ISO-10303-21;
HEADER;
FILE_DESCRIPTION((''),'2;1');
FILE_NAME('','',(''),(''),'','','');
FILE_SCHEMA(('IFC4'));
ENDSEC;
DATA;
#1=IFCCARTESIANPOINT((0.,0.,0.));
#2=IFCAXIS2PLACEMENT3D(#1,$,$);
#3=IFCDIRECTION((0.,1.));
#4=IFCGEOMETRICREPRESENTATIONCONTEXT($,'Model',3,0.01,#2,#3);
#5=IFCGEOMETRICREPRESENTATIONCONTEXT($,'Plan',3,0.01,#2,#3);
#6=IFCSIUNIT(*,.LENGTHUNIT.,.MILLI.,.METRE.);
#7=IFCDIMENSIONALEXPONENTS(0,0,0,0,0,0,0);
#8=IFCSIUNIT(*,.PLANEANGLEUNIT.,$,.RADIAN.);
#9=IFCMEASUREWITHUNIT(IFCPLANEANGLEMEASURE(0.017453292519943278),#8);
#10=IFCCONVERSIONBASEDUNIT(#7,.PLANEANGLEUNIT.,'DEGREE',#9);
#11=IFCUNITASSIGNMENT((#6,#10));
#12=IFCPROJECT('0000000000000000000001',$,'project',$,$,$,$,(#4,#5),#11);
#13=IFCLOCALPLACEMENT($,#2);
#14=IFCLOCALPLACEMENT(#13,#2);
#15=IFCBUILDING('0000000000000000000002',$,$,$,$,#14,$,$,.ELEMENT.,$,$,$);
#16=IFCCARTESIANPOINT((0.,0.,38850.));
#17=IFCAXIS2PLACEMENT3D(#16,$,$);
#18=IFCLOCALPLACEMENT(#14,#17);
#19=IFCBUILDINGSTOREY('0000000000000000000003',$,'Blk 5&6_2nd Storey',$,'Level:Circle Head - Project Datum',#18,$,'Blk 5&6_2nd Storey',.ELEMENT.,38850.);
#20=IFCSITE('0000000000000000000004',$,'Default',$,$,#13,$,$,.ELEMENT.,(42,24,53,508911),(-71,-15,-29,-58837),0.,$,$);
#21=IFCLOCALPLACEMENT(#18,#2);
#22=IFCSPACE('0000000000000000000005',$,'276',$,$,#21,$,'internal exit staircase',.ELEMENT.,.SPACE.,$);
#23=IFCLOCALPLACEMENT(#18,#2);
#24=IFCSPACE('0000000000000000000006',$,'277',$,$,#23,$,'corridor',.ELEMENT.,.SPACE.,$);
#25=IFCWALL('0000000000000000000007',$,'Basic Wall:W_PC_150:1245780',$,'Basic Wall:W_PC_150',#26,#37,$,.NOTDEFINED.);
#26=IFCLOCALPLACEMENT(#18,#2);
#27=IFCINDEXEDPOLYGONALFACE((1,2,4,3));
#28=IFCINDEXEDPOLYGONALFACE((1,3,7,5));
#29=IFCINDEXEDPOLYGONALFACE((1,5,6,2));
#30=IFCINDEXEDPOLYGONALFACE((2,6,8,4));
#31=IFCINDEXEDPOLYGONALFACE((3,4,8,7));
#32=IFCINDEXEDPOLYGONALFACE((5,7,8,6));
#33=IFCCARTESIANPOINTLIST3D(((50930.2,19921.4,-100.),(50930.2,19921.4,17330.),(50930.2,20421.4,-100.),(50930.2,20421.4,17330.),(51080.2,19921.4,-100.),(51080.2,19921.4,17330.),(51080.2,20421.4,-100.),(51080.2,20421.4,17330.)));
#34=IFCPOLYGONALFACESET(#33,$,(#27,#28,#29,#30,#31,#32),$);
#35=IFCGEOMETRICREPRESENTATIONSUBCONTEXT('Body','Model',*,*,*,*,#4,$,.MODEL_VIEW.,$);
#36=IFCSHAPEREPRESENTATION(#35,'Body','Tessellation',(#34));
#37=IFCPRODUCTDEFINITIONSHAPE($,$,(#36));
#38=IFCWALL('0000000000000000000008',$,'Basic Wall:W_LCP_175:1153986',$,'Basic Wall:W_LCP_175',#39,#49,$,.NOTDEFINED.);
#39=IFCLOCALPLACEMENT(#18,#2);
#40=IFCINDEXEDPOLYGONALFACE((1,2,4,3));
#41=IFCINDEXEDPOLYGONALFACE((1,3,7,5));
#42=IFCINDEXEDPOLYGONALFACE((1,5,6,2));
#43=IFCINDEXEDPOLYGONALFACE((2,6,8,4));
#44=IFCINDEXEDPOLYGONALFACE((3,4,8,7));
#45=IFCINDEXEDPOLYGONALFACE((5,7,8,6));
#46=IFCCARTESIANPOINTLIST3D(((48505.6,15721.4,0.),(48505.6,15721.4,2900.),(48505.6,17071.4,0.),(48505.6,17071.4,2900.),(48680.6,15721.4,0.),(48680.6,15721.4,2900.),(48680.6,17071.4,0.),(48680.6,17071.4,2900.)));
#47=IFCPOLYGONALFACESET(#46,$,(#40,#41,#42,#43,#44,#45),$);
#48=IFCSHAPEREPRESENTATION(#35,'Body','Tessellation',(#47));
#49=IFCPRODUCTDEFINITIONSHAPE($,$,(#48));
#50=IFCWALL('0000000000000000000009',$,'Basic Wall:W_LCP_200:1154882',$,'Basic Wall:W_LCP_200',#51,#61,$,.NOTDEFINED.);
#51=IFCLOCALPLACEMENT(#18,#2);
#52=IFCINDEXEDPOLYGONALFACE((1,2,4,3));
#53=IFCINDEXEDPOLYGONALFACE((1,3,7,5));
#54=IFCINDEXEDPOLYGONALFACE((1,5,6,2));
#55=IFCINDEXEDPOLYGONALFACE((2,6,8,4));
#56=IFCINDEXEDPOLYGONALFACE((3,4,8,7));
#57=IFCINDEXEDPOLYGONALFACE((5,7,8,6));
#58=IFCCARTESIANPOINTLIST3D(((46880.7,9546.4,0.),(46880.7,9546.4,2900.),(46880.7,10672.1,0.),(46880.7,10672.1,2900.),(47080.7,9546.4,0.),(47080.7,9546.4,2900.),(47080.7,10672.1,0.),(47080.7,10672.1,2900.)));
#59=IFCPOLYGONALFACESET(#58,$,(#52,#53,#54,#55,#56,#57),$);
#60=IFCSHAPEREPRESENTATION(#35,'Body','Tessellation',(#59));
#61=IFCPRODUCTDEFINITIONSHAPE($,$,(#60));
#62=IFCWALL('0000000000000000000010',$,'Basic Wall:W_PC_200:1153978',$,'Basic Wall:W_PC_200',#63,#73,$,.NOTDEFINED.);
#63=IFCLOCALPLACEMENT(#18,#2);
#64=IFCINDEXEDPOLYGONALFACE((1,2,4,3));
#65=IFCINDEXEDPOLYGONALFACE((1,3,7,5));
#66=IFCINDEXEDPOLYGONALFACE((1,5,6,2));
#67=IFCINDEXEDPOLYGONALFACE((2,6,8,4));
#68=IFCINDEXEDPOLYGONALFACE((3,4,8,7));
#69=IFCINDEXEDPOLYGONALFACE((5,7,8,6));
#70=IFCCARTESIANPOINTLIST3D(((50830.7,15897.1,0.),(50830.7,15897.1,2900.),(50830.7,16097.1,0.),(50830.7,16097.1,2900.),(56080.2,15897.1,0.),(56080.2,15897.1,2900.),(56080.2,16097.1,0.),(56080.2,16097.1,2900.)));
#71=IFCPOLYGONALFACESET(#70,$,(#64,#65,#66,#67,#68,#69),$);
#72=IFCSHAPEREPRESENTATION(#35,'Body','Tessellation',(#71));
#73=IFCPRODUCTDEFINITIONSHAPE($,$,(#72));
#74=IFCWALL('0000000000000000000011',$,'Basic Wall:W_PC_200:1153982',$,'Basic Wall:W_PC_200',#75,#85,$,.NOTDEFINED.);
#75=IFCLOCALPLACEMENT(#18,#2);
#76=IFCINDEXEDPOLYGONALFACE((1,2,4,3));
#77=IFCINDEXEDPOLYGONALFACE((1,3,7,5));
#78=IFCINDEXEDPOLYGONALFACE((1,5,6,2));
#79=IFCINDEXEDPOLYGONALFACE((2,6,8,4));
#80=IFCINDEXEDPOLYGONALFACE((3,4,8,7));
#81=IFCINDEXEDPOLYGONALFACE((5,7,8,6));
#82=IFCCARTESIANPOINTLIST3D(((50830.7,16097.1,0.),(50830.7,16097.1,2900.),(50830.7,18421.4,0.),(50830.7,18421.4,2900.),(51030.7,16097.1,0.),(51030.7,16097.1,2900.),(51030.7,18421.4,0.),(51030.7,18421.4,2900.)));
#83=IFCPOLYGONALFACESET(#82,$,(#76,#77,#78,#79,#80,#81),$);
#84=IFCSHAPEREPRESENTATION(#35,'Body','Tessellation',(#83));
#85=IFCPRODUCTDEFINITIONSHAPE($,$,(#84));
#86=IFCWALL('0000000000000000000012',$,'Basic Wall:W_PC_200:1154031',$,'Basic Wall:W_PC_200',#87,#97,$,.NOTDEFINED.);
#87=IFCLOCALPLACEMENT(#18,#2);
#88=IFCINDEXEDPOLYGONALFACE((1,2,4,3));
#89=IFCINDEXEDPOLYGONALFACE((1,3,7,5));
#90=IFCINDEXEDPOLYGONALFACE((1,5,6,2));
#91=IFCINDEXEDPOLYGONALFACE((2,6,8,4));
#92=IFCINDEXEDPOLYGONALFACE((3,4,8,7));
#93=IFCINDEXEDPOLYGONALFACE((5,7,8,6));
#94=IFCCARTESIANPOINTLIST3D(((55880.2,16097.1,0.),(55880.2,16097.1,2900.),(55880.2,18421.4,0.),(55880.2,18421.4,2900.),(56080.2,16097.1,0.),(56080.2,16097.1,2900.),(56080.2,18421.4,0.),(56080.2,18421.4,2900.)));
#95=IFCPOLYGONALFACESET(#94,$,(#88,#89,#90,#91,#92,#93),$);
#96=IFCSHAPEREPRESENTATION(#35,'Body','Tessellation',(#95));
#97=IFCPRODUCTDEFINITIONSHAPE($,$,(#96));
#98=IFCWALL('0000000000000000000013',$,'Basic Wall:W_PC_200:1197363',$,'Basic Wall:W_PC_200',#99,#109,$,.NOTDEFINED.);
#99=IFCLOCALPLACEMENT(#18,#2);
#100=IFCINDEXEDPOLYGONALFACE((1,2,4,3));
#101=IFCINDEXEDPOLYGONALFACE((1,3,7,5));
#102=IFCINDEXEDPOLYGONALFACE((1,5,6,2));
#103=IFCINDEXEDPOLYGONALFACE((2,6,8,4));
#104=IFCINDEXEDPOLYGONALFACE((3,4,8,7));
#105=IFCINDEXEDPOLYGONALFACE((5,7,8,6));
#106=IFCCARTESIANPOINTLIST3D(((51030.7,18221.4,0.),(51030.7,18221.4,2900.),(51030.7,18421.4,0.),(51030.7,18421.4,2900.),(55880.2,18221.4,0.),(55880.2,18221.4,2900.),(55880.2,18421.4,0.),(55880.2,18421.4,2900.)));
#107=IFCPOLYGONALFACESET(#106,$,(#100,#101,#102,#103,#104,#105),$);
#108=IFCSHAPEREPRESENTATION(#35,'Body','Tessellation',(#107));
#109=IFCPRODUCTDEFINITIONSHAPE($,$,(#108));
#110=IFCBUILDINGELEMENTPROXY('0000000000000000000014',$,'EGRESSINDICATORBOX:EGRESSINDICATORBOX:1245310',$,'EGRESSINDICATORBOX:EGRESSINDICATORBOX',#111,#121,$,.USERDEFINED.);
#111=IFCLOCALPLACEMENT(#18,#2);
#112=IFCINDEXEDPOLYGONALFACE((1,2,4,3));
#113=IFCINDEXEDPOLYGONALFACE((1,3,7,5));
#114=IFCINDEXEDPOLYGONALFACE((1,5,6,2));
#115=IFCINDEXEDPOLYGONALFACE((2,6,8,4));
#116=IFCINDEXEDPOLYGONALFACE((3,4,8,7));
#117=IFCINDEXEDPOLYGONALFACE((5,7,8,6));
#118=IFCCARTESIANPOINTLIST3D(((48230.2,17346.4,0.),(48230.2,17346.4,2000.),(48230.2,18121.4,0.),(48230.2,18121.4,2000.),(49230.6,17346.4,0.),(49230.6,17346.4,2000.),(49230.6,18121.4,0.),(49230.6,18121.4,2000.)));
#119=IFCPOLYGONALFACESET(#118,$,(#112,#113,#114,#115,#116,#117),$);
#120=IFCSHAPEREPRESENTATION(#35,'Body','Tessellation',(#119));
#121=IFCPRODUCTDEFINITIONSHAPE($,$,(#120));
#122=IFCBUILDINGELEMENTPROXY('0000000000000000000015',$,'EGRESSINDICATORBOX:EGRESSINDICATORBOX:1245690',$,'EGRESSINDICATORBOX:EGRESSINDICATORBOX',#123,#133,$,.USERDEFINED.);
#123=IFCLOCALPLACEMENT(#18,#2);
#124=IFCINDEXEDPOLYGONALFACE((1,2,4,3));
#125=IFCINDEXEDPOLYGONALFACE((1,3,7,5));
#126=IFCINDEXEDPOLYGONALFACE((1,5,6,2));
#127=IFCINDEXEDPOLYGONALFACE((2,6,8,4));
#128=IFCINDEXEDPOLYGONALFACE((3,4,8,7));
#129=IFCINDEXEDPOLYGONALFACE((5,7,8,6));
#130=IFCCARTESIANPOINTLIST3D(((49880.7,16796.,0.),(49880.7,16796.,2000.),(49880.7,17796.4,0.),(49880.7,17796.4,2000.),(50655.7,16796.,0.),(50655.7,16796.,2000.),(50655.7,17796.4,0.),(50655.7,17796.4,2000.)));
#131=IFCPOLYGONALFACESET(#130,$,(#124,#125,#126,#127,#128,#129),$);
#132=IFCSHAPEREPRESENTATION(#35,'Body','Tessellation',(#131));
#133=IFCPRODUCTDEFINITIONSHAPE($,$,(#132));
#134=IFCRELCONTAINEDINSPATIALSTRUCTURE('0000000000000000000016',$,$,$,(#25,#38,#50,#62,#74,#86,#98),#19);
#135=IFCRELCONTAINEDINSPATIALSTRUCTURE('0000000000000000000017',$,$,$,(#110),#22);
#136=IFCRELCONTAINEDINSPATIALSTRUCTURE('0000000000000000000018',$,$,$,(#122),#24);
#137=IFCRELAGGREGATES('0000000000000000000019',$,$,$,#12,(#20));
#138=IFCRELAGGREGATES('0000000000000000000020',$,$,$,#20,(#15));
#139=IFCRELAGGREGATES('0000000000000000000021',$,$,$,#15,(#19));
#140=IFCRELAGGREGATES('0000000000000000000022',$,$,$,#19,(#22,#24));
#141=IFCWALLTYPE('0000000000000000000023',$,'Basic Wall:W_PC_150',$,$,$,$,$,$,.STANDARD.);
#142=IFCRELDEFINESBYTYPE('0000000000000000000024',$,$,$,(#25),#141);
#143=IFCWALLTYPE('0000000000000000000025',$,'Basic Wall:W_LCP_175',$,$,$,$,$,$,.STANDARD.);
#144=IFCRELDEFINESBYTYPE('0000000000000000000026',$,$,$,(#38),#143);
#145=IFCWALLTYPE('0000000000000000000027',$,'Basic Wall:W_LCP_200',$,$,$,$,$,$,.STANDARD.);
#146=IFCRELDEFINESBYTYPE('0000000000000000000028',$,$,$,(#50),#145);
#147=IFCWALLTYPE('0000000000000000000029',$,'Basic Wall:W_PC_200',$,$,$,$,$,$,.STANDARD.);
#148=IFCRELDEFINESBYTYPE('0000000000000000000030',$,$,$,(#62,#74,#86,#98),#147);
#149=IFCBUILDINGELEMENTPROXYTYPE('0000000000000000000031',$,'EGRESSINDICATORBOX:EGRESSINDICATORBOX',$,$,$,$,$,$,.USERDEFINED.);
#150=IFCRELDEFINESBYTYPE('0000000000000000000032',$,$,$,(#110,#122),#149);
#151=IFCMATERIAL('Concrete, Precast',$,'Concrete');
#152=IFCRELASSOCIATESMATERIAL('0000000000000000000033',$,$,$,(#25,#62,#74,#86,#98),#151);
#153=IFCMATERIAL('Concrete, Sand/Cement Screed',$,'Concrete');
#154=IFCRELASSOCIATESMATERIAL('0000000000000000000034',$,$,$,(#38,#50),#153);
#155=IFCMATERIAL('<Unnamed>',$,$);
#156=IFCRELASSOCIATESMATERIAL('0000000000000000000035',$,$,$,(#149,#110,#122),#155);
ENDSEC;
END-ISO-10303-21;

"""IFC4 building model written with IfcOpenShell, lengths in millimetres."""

from ifc_helpers import new_model, entity, si_unit, converted_unit, direction, frame, origin, place, context, subcontext, project, spatial, indexed_curve, outline, extrude, source, transform, mapped, material, type_object, type_shapes, element, save


model = new_model("IFC4")

# Units and contexts
model_context = context("Model", 3, precision=0.01, world=origin(), true_north=direction((0.0, 1.0)))
plan_context = context("Plan", 3, precision=0.01, world=origin(), true_north=direction((0.0, 1.0)))
body_context = subcontext(model_context, "Body", "Model", "MODEL_VIEW")
ifc_project = project(units=[si_unit("LENGTHUNIT", "METRE", prefix="MILLI"), converted_unit("PLANEANGLEUNIT", "DEGREE", entity("IfcPlaneAngleMeasure", 0.017453292519943278), si_unit("PLANEANGLEUNIT", "RADIAN"), dimensions=[0, 0, 0, 0, 0, 0, 0])], contexts=[model_context, plan_context])

# Site, building, storey
site_placement = place(None, origin())
site = spatial("IfcSite", under=ifc_project, at=site_placement, Name="Default", CompositionType="ELEMENT", RefLatitude=(42, 24, 53, 508911), RefLongitude=(-71, -15, -29, -58837), RefElevation=0.0)
building_placement = place(site_placement, origin())
building = spatial("IfcBuilding", under=site, at=building_placement, CompositionType="ELEMENT")
storey_placement = place(building_placement, frame((0.0, 0.0, 38850.0)))
storey = spatial("IfcBuildingStorey", under=building, at=storey_placement, Name="Blk 5&6_2nd Storey", ObjectType="Level:Circle Head - Project Datum", LongName="Blk 5&6_2nd Storey", CompositionType="ELEMENT", Elevation=38850.0)

# Walls
ifc_material_1 = material(Name="Concrete, Sand/Cement Screed", Category="Concrete")
ifc_material_2 = material(Name="Concrete, Precast", Category="Concrete")
wall_type_1 = type_object("IfcWallType", Name="Basic Wall:W_PC_150", PredefinedType="STANDARD")
wall_1_placement = place(storey_placement, frame((51005.2, 19921.4, -100.0), z_axis=(0.0, 0.0, 1.0), x_axis=(0.0, 1.0, 0.0)))
element("IfcWall", 1, at=wall_1_placement, inside=storey, type_object=wall_type_1, material=ifc_material_2, Name="Basic Wall:W_PC_150:1245780", ObjectType="Basic Wall:W_PC_150", PredefinedType="NOTDEFINED", context=body_context, shape_type="SweptSolid", body=[
    extrude(outline(indexed_curve([(500.0, 75.0), (0.0, 75.0), (0.0, -75.0), (500.0, -75.0), (500.0, 75.0)], self_intersect=False)), origin(), (0.0, 0.0, 1.0), 17430.0),
])
wall_type_2 = type_object("IfcWallType", Name="Basic Wall:W_LCP_175", PredefinedType="STANDARD")
wall_2_placement = place(storey_placement, frame((48593.1, 15721.4, 0.0), z_axis=(0.0, 0.0, 1.0), x_axis=(0.0, 1.0, 0.0)))
element("IfcWall", 2, at=wall_2_placement, inside=storey, type_object=wall_type_2, material=ifc_material_1, Name="Basic Wall:W_LCP_175:1153986", ObjectType="Basic Wall:W_LCP_175", PredefinedType="NOTDEFINED", context=body_context, shape_type="SweptSolid", body=[
    extrude(outline(indexed_curve([(1350.0, 87.5), (0.0, 87.5), (0.0, -87.5), (1350.0, -87.5), (1350.0, 87.5)], self_intersect=False)), origin(), (0.0, 0.0, 1.0), 2900.0),
])
wall_type_3 = type_object("IfcWallType", Name="Basic Wall:W_LCP_200", PredefinedType="STANDARD")
wall_3_placement = place(storey_placement, frame((46980.7, 9546.4, 0.0), z_axis=(0.0, 0.0, 1.0), x_axis=(0.0, 1.0, 0.0)))
element("IfcWall", 3, at=wall_3_placement, inside=storey, type_object=wall_type_3, material=ifc_material_1, Name="Basic Wall:W_LCP_200:1154882", ObjectType="Basic Wall:W_LCP_200", PredefinedType="NOTDEFINED", context=body_context, shape_type="SweptSolid", body=[
    extrude(outline(indexed_curve([(1125.7, 100.0), (0.0, 100.0), (0.0, -100.0), (1125.7, -100.0), (1125.7, 100.0)], self_intersect=False)), origin(), (0.0, 0.0, 1.0), 2900.0),
])
wall_type_4 = type_object("IfcWallType", Name="Basic Wall:W_PC_200", PredefinedType="STANDARD")
wall_4_placement = place(storey_placement, frame((50830.7, 15997.1, 0.0)))
element("IfcWall", 4, at=wall_4_placement, inside=storey, type_object=wall_type_4, material=ifc_material_2, Name="Basic Wall:W_PC_200:1153978", ObjectType="Basic Wall:W_PC_200", PredefinedType="NOTDEFINED", context=body_context, shape_type="SweptSolid", body=[
    extrude(outline(indexed_curve([(5249.5, 100.0), (0.0, 100.0), (0.0, -100.0), (5249.5, -100.0), (5249.5, 100.0)], self_intersect=False)), origin(), (0.0, 0.0, 1.0), 2900.0),
])
for number, where, z_axis, x_axis, name in (
    (5, (50930.7, 18421.4, 0.0), (0.0, 0.0, 1.0), (0.0, -1.0, 0.0), "Basic Wall:W_PC_200:1153982"),
    (6, (55980.2, 16097.1, 0.0), (0.0, 0.0, 1.0), (0.0, 1.0, 0.0), "Basic Wall:W_PC_200:1154031"),
):
    element("IfcWall", number, at=place(storey_placement, frame(where, z_axis=z_axis, x_axis=x_axis)), inside=storey, type_object=wall_type_4, material=ifc_material_2, Name=name, ObjectType="Basic Wall:W_PC_200", PredefinedType="NOTDEFINED", context=body_context, shape_type="SweptSolid", body=[
        extrude(outline(indexed_curve([(2324.3, 100.0), (0.0, 100.0), (0.0, -100.0), (2324.3, -100.0), (2324.3, 100.0)], self_intersect=False)), origin(), (0.0, 0.0, 1.0), 2900.0),
    ])
wall_5_placement = place(storey_placement, frame((51030.7, 18321.4, 0.0)))
element("IfcWall", 7, at=wall_5_placement, inside=storey, type_object=wall_type_4, material=ifc_material_2, Name="Basic Wall:W_PC_200:1197363", ObjectType="Basic Wall:W_PC_200", PredefinedType="NOTDEFINED", context=body_context, shape_type="SweptSolid", body=[
    extrude(outline(indexed_curve([(4849.5, 100.0), (0.0, 100.0), (0.0, -100.0), (4849.5, -100.0), (4849.5, 100.0)], self_intersect=False)), origin(), (0.0, 0.0, 1.0), 2900.0),
])

# Shared definitions
space_1_placement = place(storey_placement, origin())
space_1 = spatial("IfcSpace", under=storey, at=space_1_placement, Name="276", LongName="internal exit staircase", CompositionType="ELEMENT", PredefinedType="SPACE")

# Building element proxy
ifc_material_3 = material(Name="<Unnamed>")
building_element_proxy_type = type_object("IfcBuildingElementProxyType", Name="EGRESSINDICATORBOX:EGRESSINDICATORBOX", PredefinedType="USERDEFINED", material=ifc_material_3)
shared_shape = source(origin(), body_context, "Body", "SweptSolid", [
    extrude(outline(indexed_curve([(-387.5, -500.2), (387.5, -500.2), (387.5, 500.2), (-387.5, 500.2), (-387.5, -500.2)], self_intersect=False)), frame((0.0, 0.0, 0.0), z_axis=(0.0, 0.0, 1.0), x_axis=(-1.0, 0.0, 0.0)), (0.0, 0.0, 1.0), 2000.0),
])
type_shapes(building_element_proxy_type, [shared_shape])
proxy_1_placement = place(space_1_placement, frame((48730.4, 17733.9, 0.0), z_axis=(0.0, 0.0, 1.0), x_axis=(0.0, 1.0, 0.0)))
element("IfcBuildingElementProxy", 8, at=proxy_1_placement, inside=space_1, type_object=building_element_proxy_type, material=ifc_material_3, Name="EGRESSINDICATORBOX:EGRESSINDICATORBOX:1245310", ObjectType="EGRESSINDICATORBOX:EGRESSINDICATORBOX", PredefinedType="USERDEFINED", context=body_context, shape_type="MappedRepresentation", body=[
    mapped(shared_shape, transform((0.0, 0.0, 0.0), scale=1.0)),
])

# Shared definitions
space_2_placement = place(storey_placement, origin())
space_2 = spatial("IfcSpace", under=storey, at=space_2_placement, Name="277", LongName="corridor", CompositionType="ELEMENT", PredefinedType="SPACE")

# Building element proxy
proxy_2_placement = place(space_2_placement, frame((50268.2, 17296.2, 0.0)))
element("IfcBuildingElementProxy", 9, at=proxy_2_placement, inside=space_2, type_object=building_element_proxy_type, material=ifc_material_3, Name="EGRESSINDICATORBOX:EGRESSINDICATORBOX:1245690", ObjectType="EGRESSINDICATORBOX:EGRESSINDICATORBOX", PredefinedType="USERDEFINED", context=body_context, shape_type="MappedRepresentation", body=[
    mapped(shared_shape, transform((0.0, 0.0, 0.0), scale=1.0)),
])

save(model, "model.ifc")
